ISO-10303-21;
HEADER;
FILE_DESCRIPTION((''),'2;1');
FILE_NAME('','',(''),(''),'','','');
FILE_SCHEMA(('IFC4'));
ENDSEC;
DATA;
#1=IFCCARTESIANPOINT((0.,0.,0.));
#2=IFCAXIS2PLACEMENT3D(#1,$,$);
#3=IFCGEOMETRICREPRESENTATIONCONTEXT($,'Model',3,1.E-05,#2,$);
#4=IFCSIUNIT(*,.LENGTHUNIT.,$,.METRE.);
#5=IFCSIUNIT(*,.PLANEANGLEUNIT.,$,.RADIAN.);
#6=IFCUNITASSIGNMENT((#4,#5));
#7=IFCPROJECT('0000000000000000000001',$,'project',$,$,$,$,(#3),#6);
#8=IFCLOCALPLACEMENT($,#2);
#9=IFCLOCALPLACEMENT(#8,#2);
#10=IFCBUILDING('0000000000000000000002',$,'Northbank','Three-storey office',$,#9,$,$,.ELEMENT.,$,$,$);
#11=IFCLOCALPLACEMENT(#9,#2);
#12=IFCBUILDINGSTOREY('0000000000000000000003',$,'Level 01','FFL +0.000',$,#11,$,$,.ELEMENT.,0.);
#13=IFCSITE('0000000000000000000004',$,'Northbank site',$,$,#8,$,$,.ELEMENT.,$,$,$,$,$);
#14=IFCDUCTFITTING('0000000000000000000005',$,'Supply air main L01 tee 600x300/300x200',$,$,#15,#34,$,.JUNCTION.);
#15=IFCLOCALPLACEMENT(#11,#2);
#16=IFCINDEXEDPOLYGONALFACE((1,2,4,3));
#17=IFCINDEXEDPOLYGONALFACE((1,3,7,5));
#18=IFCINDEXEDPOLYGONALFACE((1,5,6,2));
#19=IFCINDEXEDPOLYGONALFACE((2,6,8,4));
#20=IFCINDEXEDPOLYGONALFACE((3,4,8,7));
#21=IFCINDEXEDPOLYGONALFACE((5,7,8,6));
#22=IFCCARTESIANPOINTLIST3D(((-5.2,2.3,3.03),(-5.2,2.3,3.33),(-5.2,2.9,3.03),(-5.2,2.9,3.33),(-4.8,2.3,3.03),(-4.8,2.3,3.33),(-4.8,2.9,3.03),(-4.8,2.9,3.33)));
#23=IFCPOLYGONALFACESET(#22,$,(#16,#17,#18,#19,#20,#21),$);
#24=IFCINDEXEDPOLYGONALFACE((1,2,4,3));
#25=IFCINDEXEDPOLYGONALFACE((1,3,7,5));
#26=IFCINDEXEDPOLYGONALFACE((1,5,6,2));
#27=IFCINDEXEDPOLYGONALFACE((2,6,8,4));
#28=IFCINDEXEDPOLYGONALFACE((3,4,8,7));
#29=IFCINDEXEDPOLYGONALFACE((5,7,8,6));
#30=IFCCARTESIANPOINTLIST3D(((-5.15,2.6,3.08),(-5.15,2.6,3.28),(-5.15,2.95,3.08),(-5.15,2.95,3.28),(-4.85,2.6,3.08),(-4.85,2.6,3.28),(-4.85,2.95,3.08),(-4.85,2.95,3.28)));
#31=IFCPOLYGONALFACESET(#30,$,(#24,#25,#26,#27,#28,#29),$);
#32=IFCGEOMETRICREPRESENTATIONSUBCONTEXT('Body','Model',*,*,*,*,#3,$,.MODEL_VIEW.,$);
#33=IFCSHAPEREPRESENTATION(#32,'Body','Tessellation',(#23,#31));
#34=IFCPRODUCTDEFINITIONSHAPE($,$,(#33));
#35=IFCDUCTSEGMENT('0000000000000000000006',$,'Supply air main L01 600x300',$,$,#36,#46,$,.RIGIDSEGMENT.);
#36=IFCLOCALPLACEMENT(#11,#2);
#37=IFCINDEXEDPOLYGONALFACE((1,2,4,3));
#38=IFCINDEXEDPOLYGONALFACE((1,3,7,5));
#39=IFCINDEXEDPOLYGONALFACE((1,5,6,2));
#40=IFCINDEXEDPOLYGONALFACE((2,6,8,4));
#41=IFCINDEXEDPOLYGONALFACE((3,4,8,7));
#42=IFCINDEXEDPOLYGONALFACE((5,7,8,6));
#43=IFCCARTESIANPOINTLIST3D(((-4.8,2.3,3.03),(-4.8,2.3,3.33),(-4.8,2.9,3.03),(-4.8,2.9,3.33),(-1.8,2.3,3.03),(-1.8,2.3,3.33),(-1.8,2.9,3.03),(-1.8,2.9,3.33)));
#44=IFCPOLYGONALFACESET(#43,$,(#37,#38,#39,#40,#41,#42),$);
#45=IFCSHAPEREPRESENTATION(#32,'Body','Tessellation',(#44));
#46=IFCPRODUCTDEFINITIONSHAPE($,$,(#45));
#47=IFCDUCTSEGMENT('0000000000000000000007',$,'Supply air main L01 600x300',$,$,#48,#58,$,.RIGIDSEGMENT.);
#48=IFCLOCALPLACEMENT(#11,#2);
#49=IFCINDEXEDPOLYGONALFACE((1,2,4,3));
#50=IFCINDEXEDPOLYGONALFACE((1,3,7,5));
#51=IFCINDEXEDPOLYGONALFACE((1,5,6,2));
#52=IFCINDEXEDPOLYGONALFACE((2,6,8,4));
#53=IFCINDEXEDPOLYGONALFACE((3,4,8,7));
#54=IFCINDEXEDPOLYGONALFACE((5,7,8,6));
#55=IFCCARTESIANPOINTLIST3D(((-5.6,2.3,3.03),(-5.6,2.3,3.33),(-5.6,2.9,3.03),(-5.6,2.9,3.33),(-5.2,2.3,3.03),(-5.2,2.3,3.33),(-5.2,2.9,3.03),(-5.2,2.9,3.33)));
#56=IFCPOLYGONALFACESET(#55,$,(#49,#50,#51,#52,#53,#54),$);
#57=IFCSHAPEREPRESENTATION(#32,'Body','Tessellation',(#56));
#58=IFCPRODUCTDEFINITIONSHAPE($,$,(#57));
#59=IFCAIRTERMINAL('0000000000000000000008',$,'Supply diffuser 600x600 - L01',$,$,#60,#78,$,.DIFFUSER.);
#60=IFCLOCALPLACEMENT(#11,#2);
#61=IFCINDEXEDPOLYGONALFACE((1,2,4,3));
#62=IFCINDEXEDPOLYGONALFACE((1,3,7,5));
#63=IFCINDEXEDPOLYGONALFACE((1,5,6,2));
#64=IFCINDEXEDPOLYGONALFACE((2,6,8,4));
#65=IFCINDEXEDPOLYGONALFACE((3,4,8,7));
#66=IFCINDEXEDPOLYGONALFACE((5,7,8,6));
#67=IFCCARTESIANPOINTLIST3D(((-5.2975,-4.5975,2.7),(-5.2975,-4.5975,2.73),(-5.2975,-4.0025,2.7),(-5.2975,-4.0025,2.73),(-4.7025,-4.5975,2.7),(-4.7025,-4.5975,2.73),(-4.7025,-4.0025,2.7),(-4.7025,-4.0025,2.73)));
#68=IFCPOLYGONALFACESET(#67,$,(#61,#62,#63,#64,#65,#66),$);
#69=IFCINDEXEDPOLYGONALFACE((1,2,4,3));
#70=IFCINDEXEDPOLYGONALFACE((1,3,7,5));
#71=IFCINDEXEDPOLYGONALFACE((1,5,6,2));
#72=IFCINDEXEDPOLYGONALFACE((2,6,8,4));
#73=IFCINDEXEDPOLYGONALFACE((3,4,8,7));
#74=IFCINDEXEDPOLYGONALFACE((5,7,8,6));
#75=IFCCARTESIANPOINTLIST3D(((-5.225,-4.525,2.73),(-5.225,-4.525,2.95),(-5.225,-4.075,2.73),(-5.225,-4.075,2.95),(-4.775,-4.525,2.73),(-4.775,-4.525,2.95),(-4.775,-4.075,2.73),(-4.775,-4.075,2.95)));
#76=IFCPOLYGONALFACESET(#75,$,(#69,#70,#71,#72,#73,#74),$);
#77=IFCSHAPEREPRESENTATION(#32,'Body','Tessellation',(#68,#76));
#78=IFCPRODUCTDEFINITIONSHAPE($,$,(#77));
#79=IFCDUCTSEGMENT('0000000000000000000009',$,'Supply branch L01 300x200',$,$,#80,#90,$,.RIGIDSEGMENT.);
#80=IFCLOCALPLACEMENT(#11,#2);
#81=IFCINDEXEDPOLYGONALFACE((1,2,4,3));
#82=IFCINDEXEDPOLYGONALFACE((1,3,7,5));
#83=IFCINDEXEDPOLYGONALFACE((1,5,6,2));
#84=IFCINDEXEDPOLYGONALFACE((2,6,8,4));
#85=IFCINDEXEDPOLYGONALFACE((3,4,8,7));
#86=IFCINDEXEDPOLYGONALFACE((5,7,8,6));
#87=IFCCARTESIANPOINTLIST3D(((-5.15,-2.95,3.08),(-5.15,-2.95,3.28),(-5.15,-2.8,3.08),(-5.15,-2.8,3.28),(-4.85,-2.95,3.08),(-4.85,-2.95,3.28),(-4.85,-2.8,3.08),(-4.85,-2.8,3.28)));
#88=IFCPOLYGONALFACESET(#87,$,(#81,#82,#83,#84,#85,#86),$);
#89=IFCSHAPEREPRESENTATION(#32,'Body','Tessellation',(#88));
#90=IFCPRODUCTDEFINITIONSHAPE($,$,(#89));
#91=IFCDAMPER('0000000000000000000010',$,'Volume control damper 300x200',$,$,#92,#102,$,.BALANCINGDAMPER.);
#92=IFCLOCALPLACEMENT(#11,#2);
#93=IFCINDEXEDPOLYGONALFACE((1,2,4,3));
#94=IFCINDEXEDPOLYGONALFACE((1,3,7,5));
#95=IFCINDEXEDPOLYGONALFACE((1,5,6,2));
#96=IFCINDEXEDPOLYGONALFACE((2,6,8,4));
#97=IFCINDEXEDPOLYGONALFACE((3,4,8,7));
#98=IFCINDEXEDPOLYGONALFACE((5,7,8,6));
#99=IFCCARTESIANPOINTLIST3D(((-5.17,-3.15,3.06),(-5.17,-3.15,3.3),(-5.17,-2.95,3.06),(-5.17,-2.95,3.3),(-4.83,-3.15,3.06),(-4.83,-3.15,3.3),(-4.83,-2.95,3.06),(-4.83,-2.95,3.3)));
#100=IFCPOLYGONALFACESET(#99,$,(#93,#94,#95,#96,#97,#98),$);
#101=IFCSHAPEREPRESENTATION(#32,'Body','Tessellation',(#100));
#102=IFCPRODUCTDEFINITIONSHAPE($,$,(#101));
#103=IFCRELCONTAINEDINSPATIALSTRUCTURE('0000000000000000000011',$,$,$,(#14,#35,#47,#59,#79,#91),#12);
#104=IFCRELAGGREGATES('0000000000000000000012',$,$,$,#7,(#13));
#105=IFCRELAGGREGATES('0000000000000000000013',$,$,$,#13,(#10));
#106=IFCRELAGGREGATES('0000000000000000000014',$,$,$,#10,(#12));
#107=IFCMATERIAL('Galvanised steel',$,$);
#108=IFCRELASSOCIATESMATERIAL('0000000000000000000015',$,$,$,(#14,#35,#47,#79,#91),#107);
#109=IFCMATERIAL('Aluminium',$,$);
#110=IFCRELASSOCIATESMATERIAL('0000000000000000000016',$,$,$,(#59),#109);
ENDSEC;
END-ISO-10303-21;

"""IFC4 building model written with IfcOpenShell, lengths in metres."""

from ifc_helpers import new_model, si_unit, frame, origin, place, context, subcontext, project, spatial, rectangle, extrude, material, element, save


model = new_model("IFC4")

# Units and contexts
model_context = context("Model", 3, precision=1e-05, world=origin())
body_context = subcontext(model_context, "Body", "Model", "MODEL_VIEW")
ifc_project = project(units=[si_unit("LENGTHUNIT", "METRE"), si_unit("PLANEANGLEUNIT", "RADIAN")], contexts=[model_context])

# Site, building, storey
site_placement = place(None, origin())
site = spatial("IfcSite", under=ifc_project, at=site_placement, Name="Northbank site", CompositionType="ELEMENT")
building_placement = place(site_placement, origin())
building = spatial("IfcBuilding", under=site, at=building_placement, Name="Northbank", Description="Three-storey office", CompositionType="ELEMENT")
storey_placement = place(building_placement, origin())
storey = spatial("IfcBuildingStorey", under=building, at=storey_placement, Name="Level 01", Description="FFL +0.000", CompositionType="ELEMENT", Elevation=0.0)

# Shared definitions
ifc_material_1 = material(Name="Galvanised steel")

# Duct fitting
duct_fitting_1_placement = place(storey_placement, origin())
element("IfcDuctFitting", 1, at=duct_fitting_1_placement, inside=storey, material=ifc_material_1, Name="Supply air main L01 tee 600x300/300x200", PredefinedType="JUNCTION", context=body_context, shape_type="SweptSolid", body=[
    extrude(rectangle(XDim=0.6, YDim=0.3), frame((-4.8, 2.6, 3.18), z_axis=(-1.0, 0.0, 0.0), x_axis=(0.0, -1.0, 0.0)), (0.0, 0.0, 1.0), 0.4),
    extrude(rectangle(XDim=0.3, YDim=0.2), frame((-5.0, 2.6, 3.18), z_axis=(0.0, 1.0, 0.0), x_axis=(-1.0, 0.0, 0.0)), (0.0, 0.0, 1.0), 0.35),
])

# Duct segments
duct_segment_1_placement = place(storey_placement, origin())
element("IfcDuctSegment", 2, at=duct_segment_1_placement, inside=storey, material=ifc_material_1, Name="Supply air main L01 600x300", PredefinedType="RIGIDSEGMENT", context=body_context, shape_type="SweptSolid", body=[
    extrude(rectangle(XDim=0.6, YDim=0.3), frame((-1.8, 2.6, 3.18), z_axis=(-1.0, 0.0, 0.0), x_axis=(0.0, -1.0, 0.0)), (0.0, 0.0, 1.0), 3.0),
])
duct_segment_2_placement = place(storey_placement, origin())
element("IfcDuctSegment", 3, at=duct_segment_2_placement, inside=storey, material=ifc_material_1, Name="Supply air main L01 600x300", PredefinedType="RIGIDSEGMENT", context=body_context, shape_type="SweptSolid", body=[
    extrude(rectangle(XDim=0.6, YDim=0.3), frame((-5.2, 2.6, 3.18), z_axis=(-1.0, 0.0, 0.0), x_axis=(0.0, -1.0, 0.0)), (0.0, 0.0, 1.0), 0.4),
])

# Air terminal
ifc_material_2 = material(Name="Aluminium")
air_terminal_placement = place(storey_placement, origin())
element("IfcAirTerminal", 4, at=air_terminal_placement, inside=storey, material=ifc_material_2, Name="Supply diffuser 600x600 - L01", PredefinedType="DIFFUSER", context=body_context, shape_type="SweptSolid", body=[
    extrude(rectangle(XDim=0.595, YDim=0.595), frame((-5.0, -4.3, 2.7)), (0.0, 0.0, 1.0), 0.03),
    extrude(rectangle(XDim=0.45, YDim=0.45), frame((-5.0, -4.3, 2.73)), (0.0, 0.0, 1.0), 0.22),
])

# Duct segment
duct_segment_3_placement = place(storey_placement, origin())
element("IfcDuctSegment", 5, at=duct_segment_3_placement, inside=storey, material=ifc_material_1, Name="Supply branch L01 300x200", PredefinedType="RIGIDSEGMENT", context=body_context, shape_type="SweptSolid", body=[
    extrude(rectangle(XDim=0.3, YDim=0.2), frame((-5.0, -2.8, 3.18), z_axis=(0.0, -1.0, 0.0), x_axis=(1.0, 0.0, 0.0)), (0.0, 0.0, 1.0), 0.15),
])

# Damper
damper_1_placement = place(storey_placement, origin())
element("IfcDamper", 6, at=damper_1_placement, inside=storey, material=ifc_material_1, Name="Volume control damper 300x200", PredefinedType="BALANCINGDAMPER", context=body_context, shape_type="SweptSolid", body=[
    extrude(rectangle(XDim=0.34, YDim=0.24), frame((-5.0, -2.95, 3.18), z_axis=(0.0, -1.0, 0.0), x_axis=(1.0, 0.0, 0.0)), (0.0, 0.0, 1.0), 0.2),
])

save(model, "model.ifc")
